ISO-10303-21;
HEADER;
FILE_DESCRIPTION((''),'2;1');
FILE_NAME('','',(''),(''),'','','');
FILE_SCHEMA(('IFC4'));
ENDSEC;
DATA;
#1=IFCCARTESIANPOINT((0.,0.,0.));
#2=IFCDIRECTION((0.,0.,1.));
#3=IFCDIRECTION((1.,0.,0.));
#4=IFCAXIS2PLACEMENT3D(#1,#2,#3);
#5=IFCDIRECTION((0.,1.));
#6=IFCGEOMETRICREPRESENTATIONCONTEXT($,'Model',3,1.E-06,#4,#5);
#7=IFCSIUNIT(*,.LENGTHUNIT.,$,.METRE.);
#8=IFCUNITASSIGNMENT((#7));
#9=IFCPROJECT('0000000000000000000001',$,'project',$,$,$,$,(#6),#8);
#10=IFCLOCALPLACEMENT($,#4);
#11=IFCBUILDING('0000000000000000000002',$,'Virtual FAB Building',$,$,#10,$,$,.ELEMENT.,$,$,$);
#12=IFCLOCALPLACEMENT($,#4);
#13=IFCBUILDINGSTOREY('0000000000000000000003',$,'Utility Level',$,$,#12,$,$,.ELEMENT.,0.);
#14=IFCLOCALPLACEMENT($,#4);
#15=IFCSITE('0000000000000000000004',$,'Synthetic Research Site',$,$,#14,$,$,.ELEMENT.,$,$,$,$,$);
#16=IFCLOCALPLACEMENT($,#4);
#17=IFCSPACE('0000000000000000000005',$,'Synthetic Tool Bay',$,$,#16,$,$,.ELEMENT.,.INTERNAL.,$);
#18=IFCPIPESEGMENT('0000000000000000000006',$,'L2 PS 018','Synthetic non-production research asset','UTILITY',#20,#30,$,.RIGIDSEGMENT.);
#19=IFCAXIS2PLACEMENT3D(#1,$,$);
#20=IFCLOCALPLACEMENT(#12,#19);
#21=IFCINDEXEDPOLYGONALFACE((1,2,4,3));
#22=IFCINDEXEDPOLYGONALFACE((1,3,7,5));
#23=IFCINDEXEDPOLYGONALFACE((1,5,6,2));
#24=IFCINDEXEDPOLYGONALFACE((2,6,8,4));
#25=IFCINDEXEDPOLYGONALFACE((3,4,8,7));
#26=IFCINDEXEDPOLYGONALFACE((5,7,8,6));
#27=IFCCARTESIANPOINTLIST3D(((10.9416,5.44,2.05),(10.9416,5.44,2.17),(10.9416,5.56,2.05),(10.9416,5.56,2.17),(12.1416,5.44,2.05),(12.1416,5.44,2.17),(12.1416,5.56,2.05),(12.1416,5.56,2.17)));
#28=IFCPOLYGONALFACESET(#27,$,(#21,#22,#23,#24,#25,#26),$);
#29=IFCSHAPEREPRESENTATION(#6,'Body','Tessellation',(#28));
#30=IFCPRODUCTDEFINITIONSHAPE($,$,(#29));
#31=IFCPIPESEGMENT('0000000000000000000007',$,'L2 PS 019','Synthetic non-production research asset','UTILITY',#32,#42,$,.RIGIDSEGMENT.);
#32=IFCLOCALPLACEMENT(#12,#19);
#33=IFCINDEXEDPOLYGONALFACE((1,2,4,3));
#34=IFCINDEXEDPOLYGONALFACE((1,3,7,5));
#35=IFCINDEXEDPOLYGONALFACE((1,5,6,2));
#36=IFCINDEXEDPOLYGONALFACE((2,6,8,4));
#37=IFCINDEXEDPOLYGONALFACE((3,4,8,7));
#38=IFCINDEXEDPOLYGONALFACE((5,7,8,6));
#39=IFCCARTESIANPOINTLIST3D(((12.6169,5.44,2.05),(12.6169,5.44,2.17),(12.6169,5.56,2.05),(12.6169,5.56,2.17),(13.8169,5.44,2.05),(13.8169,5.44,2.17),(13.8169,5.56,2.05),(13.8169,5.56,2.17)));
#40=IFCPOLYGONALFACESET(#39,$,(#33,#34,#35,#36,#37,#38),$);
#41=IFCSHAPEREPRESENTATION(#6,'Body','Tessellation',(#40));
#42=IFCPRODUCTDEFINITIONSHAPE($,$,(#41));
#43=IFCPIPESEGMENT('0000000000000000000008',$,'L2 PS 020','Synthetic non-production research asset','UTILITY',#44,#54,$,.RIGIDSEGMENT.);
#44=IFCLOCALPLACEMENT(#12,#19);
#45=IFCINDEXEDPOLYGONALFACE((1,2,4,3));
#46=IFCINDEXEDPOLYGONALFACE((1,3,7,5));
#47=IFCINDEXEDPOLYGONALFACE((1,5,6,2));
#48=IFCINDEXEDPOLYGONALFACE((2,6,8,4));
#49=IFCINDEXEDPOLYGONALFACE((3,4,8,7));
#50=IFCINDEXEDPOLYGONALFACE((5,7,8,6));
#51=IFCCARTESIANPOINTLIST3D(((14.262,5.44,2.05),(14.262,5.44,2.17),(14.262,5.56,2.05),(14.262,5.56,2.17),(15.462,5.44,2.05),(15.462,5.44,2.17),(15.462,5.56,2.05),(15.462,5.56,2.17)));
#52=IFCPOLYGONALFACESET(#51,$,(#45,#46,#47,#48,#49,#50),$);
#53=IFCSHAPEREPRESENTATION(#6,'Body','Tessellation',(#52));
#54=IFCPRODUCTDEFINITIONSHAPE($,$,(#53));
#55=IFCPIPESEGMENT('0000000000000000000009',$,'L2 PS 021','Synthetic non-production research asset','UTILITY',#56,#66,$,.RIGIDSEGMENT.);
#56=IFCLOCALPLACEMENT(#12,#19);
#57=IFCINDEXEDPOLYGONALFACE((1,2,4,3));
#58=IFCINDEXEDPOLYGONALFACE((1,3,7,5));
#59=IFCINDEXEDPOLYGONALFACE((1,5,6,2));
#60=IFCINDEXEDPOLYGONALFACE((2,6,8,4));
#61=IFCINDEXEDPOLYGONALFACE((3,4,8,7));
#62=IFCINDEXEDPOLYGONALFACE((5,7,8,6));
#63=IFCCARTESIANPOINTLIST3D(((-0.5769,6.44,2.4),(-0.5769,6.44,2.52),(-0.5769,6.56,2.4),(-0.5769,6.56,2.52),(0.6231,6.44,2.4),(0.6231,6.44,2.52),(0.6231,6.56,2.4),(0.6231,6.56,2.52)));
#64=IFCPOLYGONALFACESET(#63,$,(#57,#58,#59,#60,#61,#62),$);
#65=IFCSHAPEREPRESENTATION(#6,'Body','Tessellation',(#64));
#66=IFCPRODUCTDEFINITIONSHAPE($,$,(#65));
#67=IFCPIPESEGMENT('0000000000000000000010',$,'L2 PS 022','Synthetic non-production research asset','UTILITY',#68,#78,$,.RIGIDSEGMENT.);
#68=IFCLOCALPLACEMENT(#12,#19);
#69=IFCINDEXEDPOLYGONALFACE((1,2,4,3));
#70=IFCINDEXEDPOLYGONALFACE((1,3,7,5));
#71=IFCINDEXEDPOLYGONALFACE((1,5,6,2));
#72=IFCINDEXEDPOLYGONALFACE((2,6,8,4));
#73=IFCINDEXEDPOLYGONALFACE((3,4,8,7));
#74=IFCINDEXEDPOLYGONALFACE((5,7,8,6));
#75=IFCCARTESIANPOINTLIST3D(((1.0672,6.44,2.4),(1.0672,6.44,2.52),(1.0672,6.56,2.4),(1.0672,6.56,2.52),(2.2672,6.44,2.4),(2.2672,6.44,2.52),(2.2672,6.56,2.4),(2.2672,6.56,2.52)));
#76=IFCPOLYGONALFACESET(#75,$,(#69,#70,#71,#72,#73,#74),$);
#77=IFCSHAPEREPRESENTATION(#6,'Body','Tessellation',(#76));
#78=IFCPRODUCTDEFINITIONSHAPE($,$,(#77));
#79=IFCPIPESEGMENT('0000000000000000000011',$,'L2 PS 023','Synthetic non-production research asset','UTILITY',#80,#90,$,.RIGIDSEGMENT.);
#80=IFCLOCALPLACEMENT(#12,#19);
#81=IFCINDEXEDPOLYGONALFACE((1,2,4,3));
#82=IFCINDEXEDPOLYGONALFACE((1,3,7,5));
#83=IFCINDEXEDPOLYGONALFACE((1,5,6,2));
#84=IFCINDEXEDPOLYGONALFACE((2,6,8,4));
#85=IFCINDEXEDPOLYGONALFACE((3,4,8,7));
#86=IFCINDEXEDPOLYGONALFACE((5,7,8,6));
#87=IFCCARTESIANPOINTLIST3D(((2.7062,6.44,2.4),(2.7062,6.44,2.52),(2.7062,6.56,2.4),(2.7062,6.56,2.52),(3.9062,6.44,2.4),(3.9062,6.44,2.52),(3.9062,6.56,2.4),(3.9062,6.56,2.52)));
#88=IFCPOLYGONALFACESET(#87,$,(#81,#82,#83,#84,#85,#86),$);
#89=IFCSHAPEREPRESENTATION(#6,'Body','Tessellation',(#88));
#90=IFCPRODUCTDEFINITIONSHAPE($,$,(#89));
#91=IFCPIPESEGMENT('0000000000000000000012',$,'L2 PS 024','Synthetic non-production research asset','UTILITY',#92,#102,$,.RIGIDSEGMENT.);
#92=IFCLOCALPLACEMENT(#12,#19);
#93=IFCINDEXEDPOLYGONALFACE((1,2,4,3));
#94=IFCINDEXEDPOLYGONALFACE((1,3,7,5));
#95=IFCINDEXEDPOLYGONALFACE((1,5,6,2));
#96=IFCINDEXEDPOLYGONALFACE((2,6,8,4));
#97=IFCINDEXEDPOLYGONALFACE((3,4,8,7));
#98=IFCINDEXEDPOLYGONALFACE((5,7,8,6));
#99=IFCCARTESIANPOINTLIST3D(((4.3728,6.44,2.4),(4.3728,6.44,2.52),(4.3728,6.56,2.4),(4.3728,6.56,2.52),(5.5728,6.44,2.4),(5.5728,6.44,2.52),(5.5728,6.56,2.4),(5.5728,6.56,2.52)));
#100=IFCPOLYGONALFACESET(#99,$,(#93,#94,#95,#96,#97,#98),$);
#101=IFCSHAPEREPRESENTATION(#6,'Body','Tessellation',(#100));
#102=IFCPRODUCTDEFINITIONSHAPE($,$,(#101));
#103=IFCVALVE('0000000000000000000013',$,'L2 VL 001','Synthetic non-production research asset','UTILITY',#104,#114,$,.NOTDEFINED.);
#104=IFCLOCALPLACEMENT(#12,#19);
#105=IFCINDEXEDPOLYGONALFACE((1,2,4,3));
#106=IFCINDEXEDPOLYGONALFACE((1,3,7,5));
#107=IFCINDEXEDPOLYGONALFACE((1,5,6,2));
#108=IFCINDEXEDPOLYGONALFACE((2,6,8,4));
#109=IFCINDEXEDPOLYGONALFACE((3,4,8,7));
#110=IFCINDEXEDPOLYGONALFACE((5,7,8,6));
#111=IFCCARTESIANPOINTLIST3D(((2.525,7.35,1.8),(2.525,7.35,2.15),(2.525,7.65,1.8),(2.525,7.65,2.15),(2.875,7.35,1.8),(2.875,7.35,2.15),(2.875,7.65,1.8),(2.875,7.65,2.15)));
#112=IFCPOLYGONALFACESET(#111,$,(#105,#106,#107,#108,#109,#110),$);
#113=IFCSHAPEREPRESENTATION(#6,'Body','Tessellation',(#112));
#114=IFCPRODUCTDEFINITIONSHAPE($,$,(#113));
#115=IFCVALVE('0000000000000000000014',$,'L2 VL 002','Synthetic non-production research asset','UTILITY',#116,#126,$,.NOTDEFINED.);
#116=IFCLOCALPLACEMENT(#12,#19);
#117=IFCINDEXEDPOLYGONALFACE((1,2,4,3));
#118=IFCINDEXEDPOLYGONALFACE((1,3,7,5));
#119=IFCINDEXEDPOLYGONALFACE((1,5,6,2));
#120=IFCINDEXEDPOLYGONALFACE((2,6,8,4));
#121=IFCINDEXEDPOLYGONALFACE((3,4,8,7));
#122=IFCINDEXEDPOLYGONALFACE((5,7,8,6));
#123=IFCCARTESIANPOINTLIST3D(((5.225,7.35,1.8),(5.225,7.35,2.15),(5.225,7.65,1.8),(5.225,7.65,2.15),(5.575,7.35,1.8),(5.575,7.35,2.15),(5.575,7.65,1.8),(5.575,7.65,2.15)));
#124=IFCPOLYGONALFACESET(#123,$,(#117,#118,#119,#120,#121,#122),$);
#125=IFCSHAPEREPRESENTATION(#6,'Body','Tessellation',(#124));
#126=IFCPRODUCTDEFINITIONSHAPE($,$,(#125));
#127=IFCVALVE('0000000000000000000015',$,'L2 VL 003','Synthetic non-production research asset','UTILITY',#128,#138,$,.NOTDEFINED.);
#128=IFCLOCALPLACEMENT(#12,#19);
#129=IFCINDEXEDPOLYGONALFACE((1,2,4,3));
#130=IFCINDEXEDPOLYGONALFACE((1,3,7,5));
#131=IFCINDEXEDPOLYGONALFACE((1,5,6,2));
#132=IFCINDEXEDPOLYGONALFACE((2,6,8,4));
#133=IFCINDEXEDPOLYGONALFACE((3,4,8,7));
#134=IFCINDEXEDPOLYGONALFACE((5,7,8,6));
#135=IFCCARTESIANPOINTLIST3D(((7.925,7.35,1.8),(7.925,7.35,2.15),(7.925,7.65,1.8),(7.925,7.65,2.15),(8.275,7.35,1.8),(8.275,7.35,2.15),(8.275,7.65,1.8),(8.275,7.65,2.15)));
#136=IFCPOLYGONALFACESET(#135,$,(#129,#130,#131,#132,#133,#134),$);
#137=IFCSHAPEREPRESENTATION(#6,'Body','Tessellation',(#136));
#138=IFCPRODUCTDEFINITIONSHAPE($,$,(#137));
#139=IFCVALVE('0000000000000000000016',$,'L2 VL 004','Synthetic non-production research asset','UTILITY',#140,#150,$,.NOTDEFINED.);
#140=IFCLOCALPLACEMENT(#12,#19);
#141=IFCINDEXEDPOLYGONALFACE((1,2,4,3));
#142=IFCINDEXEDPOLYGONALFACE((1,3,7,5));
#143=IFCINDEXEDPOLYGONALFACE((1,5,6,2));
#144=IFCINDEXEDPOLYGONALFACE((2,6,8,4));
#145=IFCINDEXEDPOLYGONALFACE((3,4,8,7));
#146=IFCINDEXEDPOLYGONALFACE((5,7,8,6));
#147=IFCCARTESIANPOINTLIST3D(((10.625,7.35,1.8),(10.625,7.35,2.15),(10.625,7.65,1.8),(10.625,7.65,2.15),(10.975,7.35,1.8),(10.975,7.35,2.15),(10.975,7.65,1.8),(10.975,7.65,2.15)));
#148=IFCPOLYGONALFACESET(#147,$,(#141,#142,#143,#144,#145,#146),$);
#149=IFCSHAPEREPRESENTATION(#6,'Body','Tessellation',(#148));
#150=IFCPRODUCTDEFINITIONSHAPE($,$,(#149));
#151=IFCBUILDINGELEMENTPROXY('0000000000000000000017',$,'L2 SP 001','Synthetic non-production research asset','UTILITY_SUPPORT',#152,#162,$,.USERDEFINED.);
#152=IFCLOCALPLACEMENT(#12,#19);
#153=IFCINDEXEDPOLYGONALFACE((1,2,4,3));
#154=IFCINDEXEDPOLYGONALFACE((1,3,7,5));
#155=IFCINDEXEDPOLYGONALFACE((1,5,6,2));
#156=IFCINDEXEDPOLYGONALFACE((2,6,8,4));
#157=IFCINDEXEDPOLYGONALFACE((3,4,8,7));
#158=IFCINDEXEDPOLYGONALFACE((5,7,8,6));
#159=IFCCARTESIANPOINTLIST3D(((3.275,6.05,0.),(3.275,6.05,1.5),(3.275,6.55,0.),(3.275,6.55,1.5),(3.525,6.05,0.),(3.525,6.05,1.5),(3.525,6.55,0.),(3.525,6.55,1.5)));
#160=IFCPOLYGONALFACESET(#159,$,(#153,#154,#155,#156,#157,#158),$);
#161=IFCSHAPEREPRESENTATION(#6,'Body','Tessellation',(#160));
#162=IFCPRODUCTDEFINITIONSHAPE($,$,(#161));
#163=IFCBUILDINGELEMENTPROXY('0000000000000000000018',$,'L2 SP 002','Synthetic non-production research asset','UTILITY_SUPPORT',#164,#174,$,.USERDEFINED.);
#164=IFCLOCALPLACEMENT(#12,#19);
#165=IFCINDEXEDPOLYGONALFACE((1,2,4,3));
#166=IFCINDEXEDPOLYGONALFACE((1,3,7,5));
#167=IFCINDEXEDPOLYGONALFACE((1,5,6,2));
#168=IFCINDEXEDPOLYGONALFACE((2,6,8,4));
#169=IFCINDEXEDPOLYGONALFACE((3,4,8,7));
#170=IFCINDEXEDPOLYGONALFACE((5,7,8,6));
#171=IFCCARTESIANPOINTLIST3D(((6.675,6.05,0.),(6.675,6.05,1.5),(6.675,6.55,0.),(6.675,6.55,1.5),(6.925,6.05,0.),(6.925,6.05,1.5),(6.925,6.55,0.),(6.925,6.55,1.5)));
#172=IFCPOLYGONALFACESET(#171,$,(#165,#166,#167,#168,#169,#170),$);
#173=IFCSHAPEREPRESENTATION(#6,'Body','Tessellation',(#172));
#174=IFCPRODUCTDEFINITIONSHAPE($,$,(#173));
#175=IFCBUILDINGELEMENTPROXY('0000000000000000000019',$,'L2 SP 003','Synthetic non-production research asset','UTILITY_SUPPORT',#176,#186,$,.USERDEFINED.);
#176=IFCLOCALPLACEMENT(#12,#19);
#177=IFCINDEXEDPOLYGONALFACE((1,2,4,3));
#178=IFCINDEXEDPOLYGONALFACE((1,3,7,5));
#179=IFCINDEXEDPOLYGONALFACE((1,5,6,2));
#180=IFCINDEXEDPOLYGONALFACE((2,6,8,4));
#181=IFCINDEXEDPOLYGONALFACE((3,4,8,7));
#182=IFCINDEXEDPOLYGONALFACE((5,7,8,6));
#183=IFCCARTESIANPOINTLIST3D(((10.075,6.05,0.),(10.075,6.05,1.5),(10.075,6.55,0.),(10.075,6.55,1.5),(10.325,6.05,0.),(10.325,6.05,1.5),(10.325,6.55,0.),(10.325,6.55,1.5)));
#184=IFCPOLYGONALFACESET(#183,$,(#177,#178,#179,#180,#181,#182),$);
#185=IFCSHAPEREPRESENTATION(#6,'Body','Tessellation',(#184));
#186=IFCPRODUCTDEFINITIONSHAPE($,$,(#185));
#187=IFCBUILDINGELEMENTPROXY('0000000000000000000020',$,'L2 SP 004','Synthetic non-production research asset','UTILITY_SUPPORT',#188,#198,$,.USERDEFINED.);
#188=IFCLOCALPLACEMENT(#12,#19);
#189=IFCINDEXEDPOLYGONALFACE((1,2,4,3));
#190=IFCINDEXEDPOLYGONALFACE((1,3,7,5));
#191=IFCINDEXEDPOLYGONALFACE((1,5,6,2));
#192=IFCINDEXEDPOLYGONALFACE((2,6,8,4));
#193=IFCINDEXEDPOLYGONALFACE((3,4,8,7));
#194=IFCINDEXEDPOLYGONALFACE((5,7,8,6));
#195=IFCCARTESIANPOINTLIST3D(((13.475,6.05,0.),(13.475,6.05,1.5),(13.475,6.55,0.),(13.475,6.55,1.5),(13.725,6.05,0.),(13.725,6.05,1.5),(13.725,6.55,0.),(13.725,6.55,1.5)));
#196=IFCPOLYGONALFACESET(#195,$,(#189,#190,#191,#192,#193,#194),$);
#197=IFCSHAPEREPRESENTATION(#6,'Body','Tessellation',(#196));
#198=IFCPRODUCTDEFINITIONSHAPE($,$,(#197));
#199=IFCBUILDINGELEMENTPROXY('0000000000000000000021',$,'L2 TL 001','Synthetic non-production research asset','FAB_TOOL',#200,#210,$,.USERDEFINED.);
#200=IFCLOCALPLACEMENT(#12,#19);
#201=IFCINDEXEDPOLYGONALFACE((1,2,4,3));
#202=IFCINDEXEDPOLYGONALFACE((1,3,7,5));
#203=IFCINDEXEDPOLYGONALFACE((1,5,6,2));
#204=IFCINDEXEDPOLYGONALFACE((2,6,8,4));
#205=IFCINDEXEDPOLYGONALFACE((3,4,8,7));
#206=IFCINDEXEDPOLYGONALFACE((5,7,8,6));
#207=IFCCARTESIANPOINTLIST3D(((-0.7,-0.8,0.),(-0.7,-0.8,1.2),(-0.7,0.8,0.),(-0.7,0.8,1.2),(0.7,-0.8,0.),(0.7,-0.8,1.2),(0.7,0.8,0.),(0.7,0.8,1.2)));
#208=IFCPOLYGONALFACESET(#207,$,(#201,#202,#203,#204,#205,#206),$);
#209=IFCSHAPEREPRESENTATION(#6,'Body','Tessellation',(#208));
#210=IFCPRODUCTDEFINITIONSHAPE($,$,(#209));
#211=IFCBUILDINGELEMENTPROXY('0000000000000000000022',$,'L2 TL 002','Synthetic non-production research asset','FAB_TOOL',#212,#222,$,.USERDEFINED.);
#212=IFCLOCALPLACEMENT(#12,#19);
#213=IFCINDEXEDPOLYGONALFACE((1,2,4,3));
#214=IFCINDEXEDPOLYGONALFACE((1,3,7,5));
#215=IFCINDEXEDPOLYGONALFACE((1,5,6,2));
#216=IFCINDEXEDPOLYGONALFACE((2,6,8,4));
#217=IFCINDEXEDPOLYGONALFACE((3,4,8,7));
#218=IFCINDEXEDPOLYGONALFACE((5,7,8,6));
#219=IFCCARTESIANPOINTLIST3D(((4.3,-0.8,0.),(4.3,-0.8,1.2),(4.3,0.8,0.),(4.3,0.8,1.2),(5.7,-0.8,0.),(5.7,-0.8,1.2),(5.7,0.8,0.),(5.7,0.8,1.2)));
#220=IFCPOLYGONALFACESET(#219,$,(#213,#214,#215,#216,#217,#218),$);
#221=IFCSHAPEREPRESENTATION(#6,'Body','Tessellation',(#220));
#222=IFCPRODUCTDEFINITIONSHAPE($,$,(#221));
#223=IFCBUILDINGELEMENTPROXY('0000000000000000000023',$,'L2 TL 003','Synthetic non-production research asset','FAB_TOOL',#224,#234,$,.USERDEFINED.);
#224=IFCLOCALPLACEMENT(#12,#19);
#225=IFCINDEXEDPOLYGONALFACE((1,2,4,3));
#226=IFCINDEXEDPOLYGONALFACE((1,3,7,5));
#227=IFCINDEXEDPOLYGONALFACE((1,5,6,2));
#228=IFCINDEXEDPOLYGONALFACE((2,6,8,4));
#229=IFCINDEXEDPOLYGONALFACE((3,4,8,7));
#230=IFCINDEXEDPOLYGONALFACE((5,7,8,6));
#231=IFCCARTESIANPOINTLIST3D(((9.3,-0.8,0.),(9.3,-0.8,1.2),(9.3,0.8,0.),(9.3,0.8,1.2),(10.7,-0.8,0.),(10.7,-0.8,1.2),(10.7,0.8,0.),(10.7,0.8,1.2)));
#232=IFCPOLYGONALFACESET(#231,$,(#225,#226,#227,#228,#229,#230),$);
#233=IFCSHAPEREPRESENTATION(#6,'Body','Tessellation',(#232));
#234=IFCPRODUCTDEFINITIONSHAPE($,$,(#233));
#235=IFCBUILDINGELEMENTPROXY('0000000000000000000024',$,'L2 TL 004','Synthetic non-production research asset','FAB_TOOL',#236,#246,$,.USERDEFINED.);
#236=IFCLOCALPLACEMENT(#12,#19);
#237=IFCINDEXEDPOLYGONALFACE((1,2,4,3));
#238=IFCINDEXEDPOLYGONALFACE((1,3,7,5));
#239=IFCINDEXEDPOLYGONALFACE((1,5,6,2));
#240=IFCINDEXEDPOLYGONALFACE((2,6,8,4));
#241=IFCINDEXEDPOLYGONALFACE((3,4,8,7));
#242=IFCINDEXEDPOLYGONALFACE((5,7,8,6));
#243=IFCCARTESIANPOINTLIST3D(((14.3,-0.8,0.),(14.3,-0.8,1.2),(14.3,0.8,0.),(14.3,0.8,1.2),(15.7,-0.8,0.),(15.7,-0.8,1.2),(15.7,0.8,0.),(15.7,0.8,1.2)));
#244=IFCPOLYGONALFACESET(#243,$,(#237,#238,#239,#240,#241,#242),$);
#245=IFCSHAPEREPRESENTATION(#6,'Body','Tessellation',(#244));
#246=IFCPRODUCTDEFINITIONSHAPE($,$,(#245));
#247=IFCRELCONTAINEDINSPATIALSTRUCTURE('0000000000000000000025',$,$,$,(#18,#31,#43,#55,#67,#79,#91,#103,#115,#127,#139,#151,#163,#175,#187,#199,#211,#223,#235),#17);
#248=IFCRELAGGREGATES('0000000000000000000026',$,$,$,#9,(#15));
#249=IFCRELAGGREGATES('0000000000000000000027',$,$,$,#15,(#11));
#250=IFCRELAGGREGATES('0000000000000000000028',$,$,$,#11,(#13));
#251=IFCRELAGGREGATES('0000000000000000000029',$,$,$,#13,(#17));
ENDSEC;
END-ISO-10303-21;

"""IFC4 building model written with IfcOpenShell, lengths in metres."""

from ifc_helpers import new_model, si_unit, direction, frame, origin_with_axes, origin_2d_with_axis, place, context, project, spatial, rectangle, extrude, element, save


model = new_model("IFC4")

# Units and contexts
model_context = context("Model", 3, precision=1e-06, world=origin_with_axes(), true_north=direction((0.0, 1.0)))
ifc_project = project(units=[si_unit("LENGTHUNIT", "METRE")], contexts=[model_context])

# Site, building, storey, space
site_placement = place(None, origin_with_axes())
site = spatial("IfcSite", under=ifc_project, at=site_placement, Name="Synthetic Research Site", CompositionType="ELEMENT")
building_placement = place(None, origin_with_axes())
building = spatial("IfcBuilding", under=site, at=building_placement, Name="Virtual FAB Building", CompositionType="ELEMENT")
storey_placement = place(None, origin_with_axes())
storey = spatial("IfcBuildingStorey", under=building, at=storey_placement, Name="Utility Level", CompositionType="ELEMENT", Elevation=0.0)
space_placement = place(None, origin_with_axes())
space = spatial("IfcSpace", under=storey, at=space_placement, Name="Synthetic Tool Bay", CompositionType="ELEMENT", PredefinedType="INTERNAL")

# Pipe segments
for number, where, z_axis, x_axis, name in (
    (1, (11.5416, 5.5, 2.05), (0.0, 0.0, 1.0), (1.0, 0.0, 0.0), "L2 PS 018"),
    (2, (13.2169, 5.5, 2.05), (0.0, 0.0, 1.0), (1.0, 0.0, 0.0), "L2 PS 019"),
    (3, (14.862, 5.5, 2.05), (0.0, 0.0, 1.0), (1.0, 0.0, 0.0), "L2 PS 020"),
    (4, (0.0231, 6.5, 2.4), (0.0, 0.0, 1.0), (1.0, 0.0, 0.0), "L2 PS 021"),
    (5, (1.6672, 6.5, 2.4), (0.0, 0.0, 1.0), (1.0, 0.0, 0.0), "L2 PS 022"),
    (6, (3.3062, 6.5, 2.4), (0.0, 0.0, 1.0), (1.0, 0.0, 0.0), "L2 PS 023"),
    (7, (4.9728, 6.5, 2.4), (0.0, 0.0, 1.0), (1.0, 0.0, 0.0), "L2 PS 024"),
):
    element("IfcPipeSegment", number, at=place(None, frame(where, z_axis=z_axis, x_axis=x_axis)), inside=space, Name=name, Description="Synthetic non-production research asset", ObjectType="UTILITY", PredefinedType="RIGIDSEGMENT", context=model_context, shape_type="SweptSolid", body=[
        extrude(rectangle(XDim=1.2, YDim=0.12, at=origin_2d_with_axis()), origin_with_axes(), (0.0, 0.0, 1.0), 0.12),
    ])

# Valves
for number, where, z_axis, x_axis, name in (
    (8, (2.7, 7.5, 1.8), (0.0, 0.0, 1.0), (1.0, 0.0, 0.0), "L2 VL 001"),
    (9, (5.4, 7.5, 1.8), (0.0, 0.0, 1.0), (1.0, 0.0, 0.0), "L2 VL 002"),
    (10, (8.1, 7.5, 1.8), (0.0, 0.0, 1.0), (1.0, 0.0, 0.0), "L2 VL 003"),
    (11, (10.8, 7.5, 1.8), (0.0, 0.0, 1.0), (1.0, 0.0, 0.0), "L2 VL 004"),
):
    element("IfcValve", number, at=place(None, frame(where, z_axis=z_axis, x_axis=x_axis)), inside=space, Name=name, Description="Synthetic non-production research asset", ObjectType="UTILITY", PredefinedType="NOTDEFINED", context=model_context, shape_type="SweptSolid", body=[
        extrude(rectangle(XDim=0.35, YDim=0.3, at=origin_2d_with_axis()), origin_with_axes(), (0.0, 0.0, 1.0), 0.35),
    ])

# Building element proxies
for number, where, z_axis, x_axis, name in (
    (12, (3.4, 6.3, 0.0), (0.0, 0.0, 1.0), (1.0, 0.0, 0.0), "L2 SP 001"),
    (13, (6.8, 6.3, 0.0), (0.0, 0.0, 1.0), (1.0, 0.0, 0.0), "L2 SP 002"),
    (14, (10.2, 6.3, 0.0), (0.0, 0.0, 1.0), (1.0, 0.0, 0.0), "L2 SP 003"),
    (15, (13.6, 6.3, 0.0), (0.0, 0.0, 1.0), (1.0, 0.0, 0.0), "L2 SP 004"),
):
    element("IfcBuildingElementProxy", number, at=place(None, frame(where, z_axis=z_axis, x_axis=x_axis)), inside=space, Name=name, Description="Synthetic non-production research asset", ObjectType="UTILITY_SUPPORT", PredefinedType="USERDEFINED", context=model_context, shape_type="SweptSolid", body=[
        extrude(rectangle(XDim=0.25, YDim=0.5, at=origin_2d_with_axis()), origin_with_axes(), (0.0, 0.0, 1.0), 1.5),
    ])
for number, where, z_axis, x_axis, name in (
    (16, (0.0, 0.0, 0.0), (0.0, 0.0, 1.0), (1.0, 0.0, 0.0), "L2 TL 001"),
    (17, (5.0, 0.0, 0.0), (0.0, 0.0, 1.0), (1.0, 0.0, 0.0), "L2 TL 002"),
    (18, (10.0, 0.0, 0.0), (0.0, 0.0, 1.0), (1.0, 0.0, 0.0), "L2 TL 003"),
    (19, (15.0, 0.0, 0.0), (0.0, 0.0, 1.0), (1.0, 0.0, 0.0), "L2 TL 004"),
):
    element("IfcBuildingElementProxy", number, at=place(None, frame(where, z_axis=z_axis, x_axis=x_axis)), inside=space, Name=name, Description="Synthetic non-production research asset", ObjectType="FAB_TOOL", PredefinedType="USERDEFINED", context=model_context, shape_type="SweptSolid", body=[
        extrude(rectangle(XDim=1.4, YDim=1.6, at=origin_2d_with_axis()), origin_with_axes(), (0.0, 0.0, 1.0), 1.2),
    ])

save(model, "model.ifc")
